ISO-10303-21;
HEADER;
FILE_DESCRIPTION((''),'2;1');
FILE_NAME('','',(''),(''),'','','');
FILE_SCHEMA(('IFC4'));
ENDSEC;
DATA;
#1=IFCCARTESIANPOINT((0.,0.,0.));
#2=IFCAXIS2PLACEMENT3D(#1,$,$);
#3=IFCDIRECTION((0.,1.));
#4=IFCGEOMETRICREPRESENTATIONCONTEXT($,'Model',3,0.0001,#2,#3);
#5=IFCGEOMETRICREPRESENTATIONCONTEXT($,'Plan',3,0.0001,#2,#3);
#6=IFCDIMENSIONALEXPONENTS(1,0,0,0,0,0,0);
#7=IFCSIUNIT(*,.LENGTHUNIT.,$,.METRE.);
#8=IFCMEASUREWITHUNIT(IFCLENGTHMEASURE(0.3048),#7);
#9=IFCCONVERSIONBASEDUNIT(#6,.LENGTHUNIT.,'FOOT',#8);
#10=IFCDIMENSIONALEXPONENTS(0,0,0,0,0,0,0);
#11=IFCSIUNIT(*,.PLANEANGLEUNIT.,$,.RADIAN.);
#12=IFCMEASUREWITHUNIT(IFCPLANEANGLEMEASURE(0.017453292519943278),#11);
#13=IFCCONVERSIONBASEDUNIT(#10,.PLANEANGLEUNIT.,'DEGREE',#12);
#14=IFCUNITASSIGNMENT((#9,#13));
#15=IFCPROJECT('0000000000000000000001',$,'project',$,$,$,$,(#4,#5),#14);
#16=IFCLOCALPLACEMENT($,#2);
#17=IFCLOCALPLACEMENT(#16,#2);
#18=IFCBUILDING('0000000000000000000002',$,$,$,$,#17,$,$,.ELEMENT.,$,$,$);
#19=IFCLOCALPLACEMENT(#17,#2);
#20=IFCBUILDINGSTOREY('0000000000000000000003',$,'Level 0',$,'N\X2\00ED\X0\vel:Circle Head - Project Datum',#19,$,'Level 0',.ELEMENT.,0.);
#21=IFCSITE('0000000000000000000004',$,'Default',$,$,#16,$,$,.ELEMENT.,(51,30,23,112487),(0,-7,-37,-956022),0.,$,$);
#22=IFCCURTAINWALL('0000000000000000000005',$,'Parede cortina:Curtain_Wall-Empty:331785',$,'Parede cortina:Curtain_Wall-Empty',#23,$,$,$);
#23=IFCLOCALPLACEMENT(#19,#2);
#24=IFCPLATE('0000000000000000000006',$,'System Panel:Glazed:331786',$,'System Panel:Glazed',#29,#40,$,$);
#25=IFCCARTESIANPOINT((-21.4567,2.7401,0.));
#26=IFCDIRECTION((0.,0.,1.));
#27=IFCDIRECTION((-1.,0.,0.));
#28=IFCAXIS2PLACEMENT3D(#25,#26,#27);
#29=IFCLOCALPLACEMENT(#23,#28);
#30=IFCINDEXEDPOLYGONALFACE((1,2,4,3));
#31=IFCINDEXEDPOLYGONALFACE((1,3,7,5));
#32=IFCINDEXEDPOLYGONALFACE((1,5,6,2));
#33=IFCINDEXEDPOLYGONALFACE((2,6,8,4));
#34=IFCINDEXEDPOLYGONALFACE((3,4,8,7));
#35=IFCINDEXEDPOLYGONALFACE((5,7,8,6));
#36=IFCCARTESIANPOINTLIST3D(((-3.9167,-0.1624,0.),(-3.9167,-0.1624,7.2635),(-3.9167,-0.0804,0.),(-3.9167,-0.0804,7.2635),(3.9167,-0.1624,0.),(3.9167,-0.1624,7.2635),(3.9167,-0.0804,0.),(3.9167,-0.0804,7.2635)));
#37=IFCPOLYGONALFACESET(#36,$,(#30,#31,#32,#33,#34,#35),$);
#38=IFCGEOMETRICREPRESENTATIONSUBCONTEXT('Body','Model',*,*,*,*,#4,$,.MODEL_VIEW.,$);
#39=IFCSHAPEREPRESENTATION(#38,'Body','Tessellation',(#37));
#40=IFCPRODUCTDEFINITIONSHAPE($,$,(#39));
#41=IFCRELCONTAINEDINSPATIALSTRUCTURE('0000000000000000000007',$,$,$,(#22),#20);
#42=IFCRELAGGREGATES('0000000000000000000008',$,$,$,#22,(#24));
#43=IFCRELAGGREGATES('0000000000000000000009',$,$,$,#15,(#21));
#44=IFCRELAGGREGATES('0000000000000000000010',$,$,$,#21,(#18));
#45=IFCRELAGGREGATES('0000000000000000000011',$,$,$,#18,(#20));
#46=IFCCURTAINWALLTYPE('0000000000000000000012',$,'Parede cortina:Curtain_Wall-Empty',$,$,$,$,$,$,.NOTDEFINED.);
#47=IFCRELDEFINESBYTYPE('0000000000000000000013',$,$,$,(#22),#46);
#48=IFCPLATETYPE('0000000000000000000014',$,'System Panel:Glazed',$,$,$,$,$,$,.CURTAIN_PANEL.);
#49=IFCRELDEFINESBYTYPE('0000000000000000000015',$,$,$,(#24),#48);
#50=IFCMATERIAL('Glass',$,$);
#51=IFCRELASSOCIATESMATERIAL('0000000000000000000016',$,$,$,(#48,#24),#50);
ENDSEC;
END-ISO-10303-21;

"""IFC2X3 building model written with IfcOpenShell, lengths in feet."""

from ifc_helpers import new_model, entity, si_unit, converted_unit, direction, frame, frame_2d, origin, place, context, subcontext, project, spatial, rectangle, extrude, source, transform, mapped, material, type_object, type_shapes, element, aggregate, save


model = new_model("IFC2X3")

# Units and contexts
model_context = context("Model", 3, precision=0.0001, world=origin(), true_north=direction((0.0, 1.0)))
plan_context = context("Plan", 3, precision=0.0001, world=origin(), true_north=direction((0.0, 1.0)))
body_context = subcontext(model_context, "Body", "Model", "MODEL_VIEW")
ifc_project = project(units=[converted_unit("LENGTHUNIT", "FOOT", entity("IfcLengthMeasure", 0.3048), si_unit("LENGTHUNIT", "METRE"), dimensions=[1, 0, 0, 0, 0, 0, 0]), converted_unit("PLANEANGLEUNIT", "DEGREE", entity("IfcPlaneAngleMeasure", 0.017453292519943278), si_unit("PLANEANGLEUNIT", "RADIAN"), dimensions=[0, 0, 0, 0, 0, 0, 0])], contexts=[model_context, plan_context])

# Site, building, storey
site_placement = place(None, origin())
site = spatial("IfcSite", under=ifc_project, at=site_placement, Name="Default", CompositionType="ELEMENT", RefLatitude=(51, 30, 23, 112487), RefLongitude=(0, -7, -37, -956022), RefElevation=0.0)
building_placement = place(site_placement, origin())
building = spatial("IfcBuilding", under=site, at=building_placement, CompositionType="ELEMENT")
storey_placement = place(building_placement, origin())
storey = spatial("IfcBuildingStorey", under=building, at=storey_placement, Name="Level 0", ObjectType="Nível:Circle Head - Project Datum", LongName="Level 0", CompositionType="ELEMENT", Elevation=0.0)

# Curtain wall, plate
curtain_wall_type = type_object("IfcCurtainWallType", Name="Parede cortina:Curtain_Wall-Empty", PredefinedType="NOTDEFINED")
curtain_wall_placement = place(storey_placement, origin())
curtain_wall = element("IfcCurtainWall", 1, at=curtain_wall_placement, inside=storey, type_object=curtain_wall_type, Name="Parede cortina:Curtain_Wall-Empty:331785", ObjectType="Parede cortina:Curtain_Wall-Empty")
ifc_material_1 = material(Name="Glass")
plate_type = type_object("IfcPlateType", Name="System Panel:Glazed", PredefinedType="CURTAIN_PANEL", material=ifc_material_1)
shared_shape = source(origin(), body_context, "Body", "SweptSolid", [
    extrude(rectangle(XDim=0.082, YDim=7.8333, at=frame_2d((0.0, 0.0), x_axis=(1.0, 0.0))), frame((0.0, -0.1214, 0.0), z_axis=(0.0, 0.0, 1.0), x_axis=(0.0, 1.0, 0.0)), (0.0, 0.0, 1.0), 7.2635),
])
type_shapes(plate_type, [shared_shape])
plate_placement = place(curtain_wall_placement, frame((-21.4567, 2.7401, 0.0), z_axis=(0.0, 0.0, 1.0), x_axis=(-1.0, 0.0, 0.0)))
plate = element("IfcPlate", 2, at=plate_placement, type_object=plate_type, material=ifc_material_1, Name="System Panel:Glazed:331786", ObjectType="System Panel:Glazed", context=body_context, shape_type="MappedRepresentation", body=[
    mapped(shared_shape, transform((0.0, 0.0, 0.0), scale=1.0)),
])
aggregate(curtain_wall, [plate])

save(model, "model.ifc")
